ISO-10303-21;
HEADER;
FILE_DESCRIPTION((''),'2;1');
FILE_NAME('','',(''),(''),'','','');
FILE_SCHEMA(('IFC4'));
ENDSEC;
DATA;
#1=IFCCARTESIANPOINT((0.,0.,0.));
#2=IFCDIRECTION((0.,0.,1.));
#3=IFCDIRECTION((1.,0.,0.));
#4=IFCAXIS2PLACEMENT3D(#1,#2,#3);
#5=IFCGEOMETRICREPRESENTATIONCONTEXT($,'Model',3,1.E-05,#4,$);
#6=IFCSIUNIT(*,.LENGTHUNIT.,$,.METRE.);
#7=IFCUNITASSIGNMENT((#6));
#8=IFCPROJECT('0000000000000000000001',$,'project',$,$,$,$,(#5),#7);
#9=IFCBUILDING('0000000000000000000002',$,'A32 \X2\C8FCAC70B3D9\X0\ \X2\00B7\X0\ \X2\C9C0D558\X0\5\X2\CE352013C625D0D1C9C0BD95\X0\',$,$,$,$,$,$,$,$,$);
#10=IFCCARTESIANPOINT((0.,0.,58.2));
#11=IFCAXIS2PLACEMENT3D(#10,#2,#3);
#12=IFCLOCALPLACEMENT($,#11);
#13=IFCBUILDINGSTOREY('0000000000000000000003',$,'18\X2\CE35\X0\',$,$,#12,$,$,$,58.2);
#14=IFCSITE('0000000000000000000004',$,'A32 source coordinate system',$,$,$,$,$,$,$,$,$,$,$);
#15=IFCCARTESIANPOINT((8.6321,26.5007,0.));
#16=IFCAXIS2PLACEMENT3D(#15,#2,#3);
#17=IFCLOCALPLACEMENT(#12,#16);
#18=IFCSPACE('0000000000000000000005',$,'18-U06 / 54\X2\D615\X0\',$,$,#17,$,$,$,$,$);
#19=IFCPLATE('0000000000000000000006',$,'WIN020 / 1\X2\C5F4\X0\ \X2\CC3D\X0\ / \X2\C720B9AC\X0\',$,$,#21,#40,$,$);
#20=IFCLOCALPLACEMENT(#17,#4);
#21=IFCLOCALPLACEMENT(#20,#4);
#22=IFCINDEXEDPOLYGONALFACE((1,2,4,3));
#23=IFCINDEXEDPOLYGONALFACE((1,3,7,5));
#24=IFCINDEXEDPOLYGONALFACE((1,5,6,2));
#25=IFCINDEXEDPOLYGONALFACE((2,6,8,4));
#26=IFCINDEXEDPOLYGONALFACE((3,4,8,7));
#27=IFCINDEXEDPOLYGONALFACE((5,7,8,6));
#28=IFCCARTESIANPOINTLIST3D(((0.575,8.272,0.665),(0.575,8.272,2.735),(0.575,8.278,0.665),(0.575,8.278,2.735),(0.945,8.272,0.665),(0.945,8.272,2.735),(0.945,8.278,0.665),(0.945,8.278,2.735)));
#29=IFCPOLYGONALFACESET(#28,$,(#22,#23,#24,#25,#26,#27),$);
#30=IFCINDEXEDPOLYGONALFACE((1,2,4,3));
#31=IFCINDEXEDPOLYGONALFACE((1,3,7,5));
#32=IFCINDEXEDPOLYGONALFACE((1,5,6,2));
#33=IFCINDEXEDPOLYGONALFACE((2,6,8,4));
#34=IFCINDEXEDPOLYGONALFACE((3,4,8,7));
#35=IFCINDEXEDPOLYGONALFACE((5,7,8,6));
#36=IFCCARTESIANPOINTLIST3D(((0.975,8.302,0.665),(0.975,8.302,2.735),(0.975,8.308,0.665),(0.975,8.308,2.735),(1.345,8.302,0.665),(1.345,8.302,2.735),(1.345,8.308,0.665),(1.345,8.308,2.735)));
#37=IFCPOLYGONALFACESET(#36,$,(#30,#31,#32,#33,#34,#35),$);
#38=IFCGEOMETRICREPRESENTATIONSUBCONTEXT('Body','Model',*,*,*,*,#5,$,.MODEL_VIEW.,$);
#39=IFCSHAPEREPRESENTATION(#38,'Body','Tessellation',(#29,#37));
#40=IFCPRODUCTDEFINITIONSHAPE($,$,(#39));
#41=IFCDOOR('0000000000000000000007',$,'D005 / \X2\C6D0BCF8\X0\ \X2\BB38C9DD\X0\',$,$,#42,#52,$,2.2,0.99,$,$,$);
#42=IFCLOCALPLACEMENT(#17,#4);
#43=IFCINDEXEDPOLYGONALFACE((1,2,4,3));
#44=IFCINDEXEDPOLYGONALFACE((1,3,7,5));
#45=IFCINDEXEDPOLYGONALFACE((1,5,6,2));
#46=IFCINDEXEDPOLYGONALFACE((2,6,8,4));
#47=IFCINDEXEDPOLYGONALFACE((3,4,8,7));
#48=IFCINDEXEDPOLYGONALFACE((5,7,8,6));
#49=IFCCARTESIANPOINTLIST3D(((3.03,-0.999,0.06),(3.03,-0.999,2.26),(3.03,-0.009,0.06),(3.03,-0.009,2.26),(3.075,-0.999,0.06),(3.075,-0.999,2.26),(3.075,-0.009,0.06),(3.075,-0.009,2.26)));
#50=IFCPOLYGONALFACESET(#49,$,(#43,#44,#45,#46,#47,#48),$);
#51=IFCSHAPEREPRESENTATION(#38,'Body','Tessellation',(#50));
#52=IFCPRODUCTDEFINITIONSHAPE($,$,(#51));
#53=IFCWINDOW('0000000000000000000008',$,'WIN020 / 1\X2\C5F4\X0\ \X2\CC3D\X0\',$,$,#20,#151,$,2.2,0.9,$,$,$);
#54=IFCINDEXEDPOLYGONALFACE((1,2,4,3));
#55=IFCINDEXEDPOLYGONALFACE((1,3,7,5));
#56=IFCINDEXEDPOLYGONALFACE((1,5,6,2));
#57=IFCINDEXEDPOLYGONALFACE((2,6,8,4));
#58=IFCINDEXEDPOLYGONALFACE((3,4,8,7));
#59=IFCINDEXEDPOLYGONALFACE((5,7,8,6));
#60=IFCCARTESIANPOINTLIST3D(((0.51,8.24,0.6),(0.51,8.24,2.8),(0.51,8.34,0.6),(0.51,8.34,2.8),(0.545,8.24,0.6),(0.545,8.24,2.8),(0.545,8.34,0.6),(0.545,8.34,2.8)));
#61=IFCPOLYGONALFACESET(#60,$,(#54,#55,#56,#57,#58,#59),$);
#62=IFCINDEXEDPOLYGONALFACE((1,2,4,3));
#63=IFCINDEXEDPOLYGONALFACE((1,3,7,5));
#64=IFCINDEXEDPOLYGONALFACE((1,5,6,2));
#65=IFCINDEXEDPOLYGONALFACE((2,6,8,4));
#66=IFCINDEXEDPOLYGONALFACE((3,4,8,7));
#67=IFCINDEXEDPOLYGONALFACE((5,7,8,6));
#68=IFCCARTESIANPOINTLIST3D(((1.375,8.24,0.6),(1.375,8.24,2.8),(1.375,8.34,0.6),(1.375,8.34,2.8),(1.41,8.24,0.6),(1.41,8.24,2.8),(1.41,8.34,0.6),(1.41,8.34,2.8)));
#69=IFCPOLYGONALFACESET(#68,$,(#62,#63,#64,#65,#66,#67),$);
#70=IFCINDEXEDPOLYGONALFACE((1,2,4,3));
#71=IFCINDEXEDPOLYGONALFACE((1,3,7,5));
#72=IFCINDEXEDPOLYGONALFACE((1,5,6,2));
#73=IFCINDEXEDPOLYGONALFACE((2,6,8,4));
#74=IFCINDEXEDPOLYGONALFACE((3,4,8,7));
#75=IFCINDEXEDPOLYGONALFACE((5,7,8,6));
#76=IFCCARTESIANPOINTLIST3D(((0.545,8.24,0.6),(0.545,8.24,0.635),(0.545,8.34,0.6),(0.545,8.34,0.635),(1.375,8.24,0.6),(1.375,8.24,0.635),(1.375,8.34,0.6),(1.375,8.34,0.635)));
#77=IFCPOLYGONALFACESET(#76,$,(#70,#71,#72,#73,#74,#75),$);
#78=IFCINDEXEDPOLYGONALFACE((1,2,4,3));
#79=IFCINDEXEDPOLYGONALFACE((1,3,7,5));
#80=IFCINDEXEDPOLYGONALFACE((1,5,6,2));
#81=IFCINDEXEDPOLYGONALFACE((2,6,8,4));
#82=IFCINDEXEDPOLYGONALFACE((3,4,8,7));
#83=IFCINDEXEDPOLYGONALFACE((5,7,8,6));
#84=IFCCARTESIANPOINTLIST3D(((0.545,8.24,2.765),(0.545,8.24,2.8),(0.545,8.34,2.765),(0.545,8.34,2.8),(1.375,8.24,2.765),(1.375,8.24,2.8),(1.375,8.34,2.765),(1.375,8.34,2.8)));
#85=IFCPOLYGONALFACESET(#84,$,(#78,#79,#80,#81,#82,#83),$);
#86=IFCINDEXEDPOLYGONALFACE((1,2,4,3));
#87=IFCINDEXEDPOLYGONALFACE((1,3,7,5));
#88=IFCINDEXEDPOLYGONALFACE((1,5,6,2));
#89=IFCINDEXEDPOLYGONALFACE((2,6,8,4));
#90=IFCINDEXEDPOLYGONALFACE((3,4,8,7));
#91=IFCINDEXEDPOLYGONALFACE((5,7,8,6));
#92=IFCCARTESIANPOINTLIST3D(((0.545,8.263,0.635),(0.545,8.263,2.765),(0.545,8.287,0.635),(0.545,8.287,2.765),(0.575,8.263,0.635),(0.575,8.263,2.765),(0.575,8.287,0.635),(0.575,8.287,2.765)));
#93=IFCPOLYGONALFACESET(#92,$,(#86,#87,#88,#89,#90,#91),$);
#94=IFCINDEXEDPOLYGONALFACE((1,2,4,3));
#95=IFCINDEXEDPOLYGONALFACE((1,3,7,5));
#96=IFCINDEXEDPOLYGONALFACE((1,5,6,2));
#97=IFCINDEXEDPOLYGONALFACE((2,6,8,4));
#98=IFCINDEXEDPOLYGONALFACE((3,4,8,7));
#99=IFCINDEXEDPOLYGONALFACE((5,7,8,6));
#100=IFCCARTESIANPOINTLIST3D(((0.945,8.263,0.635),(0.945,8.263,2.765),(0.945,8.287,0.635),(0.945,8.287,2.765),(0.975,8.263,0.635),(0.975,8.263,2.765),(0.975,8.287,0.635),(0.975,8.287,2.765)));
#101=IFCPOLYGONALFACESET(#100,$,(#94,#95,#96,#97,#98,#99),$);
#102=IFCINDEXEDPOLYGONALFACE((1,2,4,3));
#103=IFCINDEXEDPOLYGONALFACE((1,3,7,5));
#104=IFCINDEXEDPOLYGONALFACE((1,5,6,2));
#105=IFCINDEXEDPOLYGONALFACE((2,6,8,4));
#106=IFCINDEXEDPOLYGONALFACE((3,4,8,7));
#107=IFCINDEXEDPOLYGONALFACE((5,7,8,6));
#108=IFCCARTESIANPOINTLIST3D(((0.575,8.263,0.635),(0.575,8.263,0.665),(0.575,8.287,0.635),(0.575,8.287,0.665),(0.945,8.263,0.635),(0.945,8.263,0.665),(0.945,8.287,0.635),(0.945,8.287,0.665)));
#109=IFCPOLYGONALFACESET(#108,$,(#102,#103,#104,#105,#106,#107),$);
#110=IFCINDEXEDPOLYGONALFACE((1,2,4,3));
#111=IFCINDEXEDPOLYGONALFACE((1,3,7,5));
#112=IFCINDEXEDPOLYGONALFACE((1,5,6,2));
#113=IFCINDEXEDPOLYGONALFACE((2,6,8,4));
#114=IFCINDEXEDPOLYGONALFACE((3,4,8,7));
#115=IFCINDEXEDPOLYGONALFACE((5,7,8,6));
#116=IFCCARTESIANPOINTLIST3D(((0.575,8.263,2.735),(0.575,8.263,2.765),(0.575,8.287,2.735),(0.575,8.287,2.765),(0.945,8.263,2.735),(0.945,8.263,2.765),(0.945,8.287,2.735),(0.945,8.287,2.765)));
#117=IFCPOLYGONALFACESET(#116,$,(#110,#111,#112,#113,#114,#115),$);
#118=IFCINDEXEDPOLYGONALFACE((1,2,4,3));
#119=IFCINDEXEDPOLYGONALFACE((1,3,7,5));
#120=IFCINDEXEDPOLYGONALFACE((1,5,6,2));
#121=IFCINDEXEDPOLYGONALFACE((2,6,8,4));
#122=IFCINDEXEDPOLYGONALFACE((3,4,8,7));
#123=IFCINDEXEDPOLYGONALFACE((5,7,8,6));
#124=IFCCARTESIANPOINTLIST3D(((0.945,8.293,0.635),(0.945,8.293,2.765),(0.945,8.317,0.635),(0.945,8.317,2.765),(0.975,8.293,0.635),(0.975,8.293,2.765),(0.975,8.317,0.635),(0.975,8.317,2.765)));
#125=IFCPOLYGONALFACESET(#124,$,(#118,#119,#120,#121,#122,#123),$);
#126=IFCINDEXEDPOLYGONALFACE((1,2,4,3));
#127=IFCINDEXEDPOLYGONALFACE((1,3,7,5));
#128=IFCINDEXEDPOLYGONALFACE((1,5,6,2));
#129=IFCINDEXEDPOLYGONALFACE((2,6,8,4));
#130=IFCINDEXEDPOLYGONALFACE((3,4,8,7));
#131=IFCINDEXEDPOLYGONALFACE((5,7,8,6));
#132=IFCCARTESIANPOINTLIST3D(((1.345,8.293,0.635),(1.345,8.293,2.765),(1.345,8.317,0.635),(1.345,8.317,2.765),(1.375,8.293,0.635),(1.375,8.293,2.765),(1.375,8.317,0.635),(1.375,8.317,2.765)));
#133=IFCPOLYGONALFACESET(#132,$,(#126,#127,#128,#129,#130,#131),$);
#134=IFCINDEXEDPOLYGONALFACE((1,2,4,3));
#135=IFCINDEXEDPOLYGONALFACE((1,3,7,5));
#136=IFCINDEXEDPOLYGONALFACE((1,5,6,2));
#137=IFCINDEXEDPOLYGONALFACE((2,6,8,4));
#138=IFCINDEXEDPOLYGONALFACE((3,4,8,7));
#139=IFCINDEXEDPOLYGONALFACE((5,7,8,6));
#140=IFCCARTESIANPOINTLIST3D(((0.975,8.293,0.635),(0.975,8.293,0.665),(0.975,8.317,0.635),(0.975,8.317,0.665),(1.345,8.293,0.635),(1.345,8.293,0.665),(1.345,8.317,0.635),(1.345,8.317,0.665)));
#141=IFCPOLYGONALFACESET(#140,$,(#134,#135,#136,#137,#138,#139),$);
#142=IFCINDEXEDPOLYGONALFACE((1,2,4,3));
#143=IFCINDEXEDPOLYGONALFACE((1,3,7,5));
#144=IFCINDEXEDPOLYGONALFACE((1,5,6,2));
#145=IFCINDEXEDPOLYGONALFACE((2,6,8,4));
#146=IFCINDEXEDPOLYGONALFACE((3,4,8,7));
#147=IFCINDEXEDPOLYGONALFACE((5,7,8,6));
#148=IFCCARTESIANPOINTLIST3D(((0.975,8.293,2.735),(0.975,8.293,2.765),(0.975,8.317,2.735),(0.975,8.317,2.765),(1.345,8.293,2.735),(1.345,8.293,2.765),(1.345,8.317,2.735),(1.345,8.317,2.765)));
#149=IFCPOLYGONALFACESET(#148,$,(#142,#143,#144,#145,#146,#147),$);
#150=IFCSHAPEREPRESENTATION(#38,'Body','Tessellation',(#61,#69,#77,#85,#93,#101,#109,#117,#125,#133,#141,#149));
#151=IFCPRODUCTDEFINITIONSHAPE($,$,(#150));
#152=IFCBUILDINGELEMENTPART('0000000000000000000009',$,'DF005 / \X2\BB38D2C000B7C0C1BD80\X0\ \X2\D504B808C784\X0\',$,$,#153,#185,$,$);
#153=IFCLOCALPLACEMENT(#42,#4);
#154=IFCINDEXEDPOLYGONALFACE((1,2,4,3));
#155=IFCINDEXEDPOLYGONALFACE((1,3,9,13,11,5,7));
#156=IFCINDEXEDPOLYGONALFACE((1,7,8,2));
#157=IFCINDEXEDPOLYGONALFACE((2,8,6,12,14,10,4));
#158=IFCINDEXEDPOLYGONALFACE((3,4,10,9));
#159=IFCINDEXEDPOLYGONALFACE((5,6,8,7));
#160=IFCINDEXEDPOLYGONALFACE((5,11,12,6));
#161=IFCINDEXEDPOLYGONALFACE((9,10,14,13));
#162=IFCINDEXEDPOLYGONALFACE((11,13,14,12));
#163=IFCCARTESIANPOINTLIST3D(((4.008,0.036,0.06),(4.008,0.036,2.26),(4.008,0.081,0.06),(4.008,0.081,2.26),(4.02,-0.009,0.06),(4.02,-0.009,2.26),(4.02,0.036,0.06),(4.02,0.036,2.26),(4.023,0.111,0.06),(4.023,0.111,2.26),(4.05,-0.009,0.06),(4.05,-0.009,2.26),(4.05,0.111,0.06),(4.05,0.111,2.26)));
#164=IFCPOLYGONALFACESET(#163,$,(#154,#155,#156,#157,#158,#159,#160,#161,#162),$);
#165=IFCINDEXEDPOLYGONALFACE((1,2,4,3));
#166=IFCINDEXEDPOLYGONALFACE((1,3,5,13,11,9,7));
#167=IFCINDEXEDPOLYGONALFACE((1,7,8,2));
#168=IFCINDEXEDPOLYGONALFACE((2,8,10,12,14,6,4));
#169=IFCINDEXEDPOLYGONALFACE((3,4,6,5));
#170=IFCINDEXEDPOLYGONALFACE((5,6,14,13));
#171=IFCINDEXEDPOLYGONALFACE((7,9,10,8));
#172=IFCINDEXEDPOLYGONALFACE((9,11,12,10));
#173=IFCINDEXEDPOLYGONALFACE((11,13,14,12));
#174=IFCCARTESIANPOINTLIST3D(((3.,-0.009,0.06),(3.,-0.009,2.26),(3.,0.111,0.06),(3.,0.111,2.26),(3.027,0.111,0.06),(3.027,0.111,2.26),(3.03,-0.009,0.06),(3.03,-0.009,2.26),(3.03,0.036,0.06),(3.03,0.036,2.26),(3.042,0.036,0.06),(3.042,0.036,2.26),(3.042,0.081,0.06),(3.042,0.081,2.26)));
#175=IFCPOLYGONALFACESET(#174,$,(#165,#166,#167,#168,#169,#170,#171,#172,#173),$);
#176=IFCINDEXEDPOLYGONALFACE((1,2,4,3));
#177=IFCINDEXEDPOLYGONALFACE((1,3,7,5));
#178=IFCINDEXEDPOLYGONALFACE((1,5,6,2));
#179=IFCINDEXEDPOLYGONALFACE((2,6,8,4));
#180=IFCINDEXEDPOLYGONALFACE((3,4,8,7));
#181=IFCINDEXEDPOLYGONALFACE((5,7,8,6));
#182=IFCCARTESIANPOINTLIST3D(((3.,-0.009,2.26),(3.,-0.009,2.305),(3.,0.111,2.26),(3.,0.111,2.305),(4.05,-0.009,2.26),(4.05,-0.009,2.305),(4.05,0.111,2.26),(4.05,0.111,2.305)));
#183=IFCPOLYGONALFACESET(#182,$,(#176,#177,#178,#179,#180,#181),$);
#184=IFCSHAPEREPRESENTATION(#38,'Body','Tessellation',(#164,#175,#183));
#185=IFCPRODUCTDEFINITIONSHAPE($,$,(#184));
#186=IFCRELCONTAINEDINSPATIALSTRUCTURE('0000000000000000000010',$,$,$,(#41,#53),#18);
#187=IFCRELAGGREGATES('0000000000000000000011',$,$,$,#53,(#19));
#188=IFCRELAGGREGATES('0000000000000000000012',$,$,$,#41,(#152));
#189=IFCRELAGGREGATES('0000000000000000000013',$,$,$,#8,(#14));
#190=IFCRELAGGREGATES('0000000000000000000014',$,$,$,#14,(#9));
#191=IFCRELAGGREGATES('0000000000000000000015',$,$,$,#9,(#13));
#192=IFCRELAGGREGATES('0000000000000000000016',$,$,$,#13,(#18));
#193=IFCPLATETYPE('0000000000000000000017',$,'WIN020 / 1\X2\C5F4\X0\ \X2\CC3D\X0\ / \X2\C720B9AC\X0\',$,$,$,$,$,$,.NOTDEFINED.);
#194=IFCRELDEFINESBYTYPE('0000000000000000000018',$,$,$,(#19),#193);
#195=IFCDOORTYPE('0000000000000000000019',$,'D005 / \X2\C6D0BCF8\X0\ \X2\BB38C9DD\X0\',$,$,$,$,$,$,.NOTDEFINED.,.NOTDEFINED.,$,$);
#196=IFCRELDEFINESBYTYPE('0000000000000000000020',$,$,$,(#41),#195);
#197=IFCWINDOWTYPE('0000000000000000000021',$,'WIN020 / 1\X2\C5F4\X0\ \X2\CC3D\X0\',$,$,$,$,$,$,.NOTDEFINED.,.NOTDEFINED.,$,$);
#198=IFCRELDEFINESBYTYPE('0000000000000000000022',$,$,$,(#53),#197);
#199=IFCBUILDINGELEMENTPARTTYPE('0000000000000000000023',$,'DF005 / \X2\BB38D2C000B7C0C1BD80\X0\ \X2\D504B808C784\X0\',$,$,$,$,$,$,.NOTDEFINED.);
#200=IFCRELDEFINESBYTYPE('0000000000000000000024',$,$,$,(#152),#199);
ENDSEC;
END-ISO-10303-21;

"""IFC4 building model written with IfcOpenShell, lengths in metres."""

from ifc_helpers import new_model, si_unit, frame, origin, origin_with_axes, place, context, subcontext, project, spatial, polyline, outline, extrude, source, transform, mapped, type_object, type_shapes, element, aggregate, save


model = new_model("IFC4")

# Units and contexts
model_context = context("Model", 3, precision=1e-05, world=origin_with_axes())
body_context = subcontext(model_context, "Body", "Model", "MODEL_VIEW")
ifc_project = project(units=[si_unit("LENGTHUNIT", "METRE")], contexts=[model_context])

# Plate
storey_placement = place(None, frame((0.0, 0.0, 58.2), z_axis=(0.0, 0.0, 1.0), x_axis=(1.0, 0.0, 0.0)))
space_1_placement = place(storey_placement, frame((8.6321, 26.5007, 0.0), z_axis=(0.0, 0.0, 1.0), x_axis=(1.0, 0.0, 0.0)))
plate_type_1 = type_object("IfcPlateType", Name="WIN020 / 1열 창 / 유리", PredefinedType="NOTDEFINED")
shared_shape_1 = source(origin(), body_context, "Body", "SweptSolid", [
    extrude(outline(polyline([(0.575, 8.272), (0.575, 8.278), (0.945, 8.278), (0.945, 8.272), (0.575, 8.272)])), frame((0.0, 0.0, 0.665)), (0.0, 0.0, 1.0), 2.07),
    extrude(outline(polyline([(0.975, 8.302), (0.975, 8.308), (1.345, 8.308), (1.345, 8.302), (0.975, 8.302)])), frame((0.0, 0.0, 0.665)), (0.0, 0.0, 1.0), 2.07),
])
type_shapes(plate_type_1, [shared_shape_1])
window_1_placement = place(space_1_placement, origin_with_axes())
plate_1_placement = place(window_1_placement, origin_with_axes())
plate_1 = element("IfcPlate", 1, at=plate_1_placement, type_object=plate_type_1, Name="WIN020 / 1열 창 / 유리", context=body_context, shape_type="MappedRepresentation", body=[
    mapped(shared_shape_1, transform((0.0, 0.0, 0.0), scale=1.0)),
])

# Site, building, storey, space
site = spatial("IfcSite", under=ifc_project, Name="A32 source coordinate system")
building = spatial("IfcBuilding", under=site, Name="A32 주거동 · 지하5층–옥탑지붕")
storey = spatial("IfcBuildingStorey", under=building, at=storey_placement, Name="18층", Elevation=58.2)
space_1 = spatial("IfcSpace", under=storey, at=space_1_placement, Name="18-U06 / 54형")

# Door
door_type_1 = type_object("IfcDoorType", Name="D005 / 원본 문짝", OperationType="NOTDEFINED", PredefinedType="NOTDEFINED")
shared_shape_2 = source(origin(), body_context, "Body", "SweptSolid", [
    extrude(outline(polyline([(3.075, -0.999), (3.03, -0.999), (3.03, -0.009), (3.075, -0.009), (3.075, -0.999)])), frame((0.0, 0.0, 0.06)), (0.0, 0.0, 1.0), 2.2),
])
type_shapes(door_type_1, [shared_shape_2])
door_1_placement = place(space_1_placement, origin_with_axes())
door_1 = element("IfcDoor", 2, at=door_1_placement, inside=space_1, type_object=door_type_1, Name="D005 / 원본 문짝", OverallHeight=2.2, OverallWidth=0.99, context=body_context, shape_type="MappedRepresentation", body=[
    mapped(shared_shape_2, transform((0.0, 0.0, 0.0), scale=1.0)),
])

# Window
window_type_1 = type_object("IfcWindowType", Name="WIN020 / 1열 창", PartitioningType="NOTDEFINED", PredefinedType="NOTDEFINED")
shared_shape_3 = source(origin(), body_context, "Body", "SweptSolid", [
    extrude(outline(polyline([(0.51, 8.24), (0.51, 8.34), (0.545, 8.34), (0.545, 8.24), (0.51, 8.24)])), frame((0.0, 0.0, 0.6)), (0.0, 0.0, 1.0), 2.2),
    extrude(outline(polyline([(1.375, 8.24), (1.375, 8.34), (1.41, 8.34), (1.41, 8.24), (1.375, 8.24)])), frame((0.0, 0.0, 0.6)), (0.0, 0.0, 1.0), 2.2),
    extrude(outline(polyline([(0.545, 8.24), (0.545, 8.34), (1.375, 8.34), (1.375, 8.24), (0.545, 8.24)])), frame((0.0, 0.0, 0.6)), (0.0, 0.0, 1.0), 0.035),
    extrude(outline(polyline([(0.545, 8.24), (0.545, 8.34), (1.375, 8.34), (1.375, 8.24), (0.545, 8.24)])), frame((0.0, 0.0, 2.765)), (0.0, 0.0, 1.0), 0.035),
    extrude(outline(polyline([(0.545, 8.263), (0.545, 8.287), (0.575, 8.287), (0.575, 8.263), (0.545, 8.263)])), frame((0.0, 0.0, 0.635)), (0.0, 0.0, 1.0), 2.13),
    extrude(outline(polyline([(0.945, 8.263), (0.945, 8.287), (0.975, 8.287), (0.975, 8.263), (0.945, 8.263)])), frame((0.0, 0.0, 0.635)), (0.0, 0.0, 1.0), 2.13),
    extrude(outline(polyline([(0.575, 8.263), (0.575, 8.287), (0.945, 8.287), (0.945, 8.263), (0.575, 8.263)])), frame((0.0, 0.0, 0.635)), (0.0, 0.0, 1.0), 0.03),
    extrude(outline(polyline([(0.575, 8.263), (0.575, 8.287), (0.945, 8.287), (0.945, 8.263), (0.575, 8.263)])), frame((0.0, 0.0, 2.735)), (0.0, 0.0, 1.0), 0.03),
    extrude(outline(polyline([(0.945, 8.293), (0.945, 8.317), (0.975, 8.317), (0.975, 8.293), (0.945, 8.293)])), frame((0.0, 0.0, 0.635)), (0.0, 0.0, 1.0), 2.13),
    extrude(outline(polyline([(1.345, 8.293), (1.345, 8.317), (1.375, 8.317), (1.375, 8.293), (1.345, 8.293)])), frame((0.0, 0.0, 0.635)), (0.0, 0.0, 1.0), 2.13),
    extrude(outline(polyline([(0.975, 8.293), (0.975, 8.317), (1.345, 8.317), (1.345, 8.293), (0.975, 8.293)])), frame((0.0, 0.0, 0.635)), (0.0, 0.0, 1.0), 0.03),
    extrude(outline(polyline([(0.975, 8.293), (0.975, 8.317), (1.345, 8.317), (1.345, 8.293), (0.975, 8.293)])), frame((0.0, 0.0, 2.735)), (0.0, 0.0, 1.0), 0.03),
])
type_shapes(window_type_1, [shared_shape_3])
window_1 = element("IfcWindow", 3, at=window_1_placement, inside=space_1, type_object=window_type_1, Name="WIN020 / 1열 창", OverallHeight=2.2, OverallWidth=0.9, context=body_context, shape_type="MappedRepresentation", body=[
    mapped(shared_shape_3, transform((0.0, 0.0, 0.0), scale=1.0)),
])
aggregate(window_1, [plate_1])

# Building element part
building_element_part_type_1 = type_object("IfcBuildingElementPartType", Name="DF005 / 문틀·상부 프레임", PredefinedType="NOTDEFINED")
shared_shape_4 = source(origin(), body_context, "Body", "SweptSolid", [
    extrude(outline(polyline([(4.02, -0.009), (4.02, 0.036), (4.008, 0.036), (4.008, 0.081), (4.023, 0.111), (4.05, 0.111), (4.05, -0.009), (4.02, -0.009)])), frame((0.0, 0.0, 0.06)), (0.0, 0.0, 1.0), 2.2),
    extrude(outline(polyline([(3.0, 0.111), (3.027, 0.111), (3.042, 0.081), (3.042, 0.036), (3.03, 0.036), (3.03, -0.009), (3.0, -0.009), (3.0, 0.111)])), frame((0.0, 0.0, 0.06)), (0.0, 0.0, 1.0), 2.2),
    extrude(outline(polyline([(3.0, -0.009), (3.0, 0.111), (4.05, 0.111), (4.05, -0.009), (3.0, -0.009)])), frame((0.0, 0.0, 2.26)), (0.0, 0.0, 1.0), 0.045),
])
type_shapes(building_element_part_type_1, [shared_shape_4])
building_element_part_1_placement = place(door_1_placement, origin_with_axes())
building_element_part_1 = element("IfcBuildingElementPart", 4, at=building_element_part_1_placement, type_object=building_element_part_type_1, Name="DF005 / 문틀·상부 프레임", context=body_context, shape_type="MappedRepresentation", body=[
    mapped(shared_shape_4, transform((0.0, 0.0, 0.0), scale=1.0)),
])
aggregate(door_1, [building_element_part_1])

save(model, "model.ifc")
